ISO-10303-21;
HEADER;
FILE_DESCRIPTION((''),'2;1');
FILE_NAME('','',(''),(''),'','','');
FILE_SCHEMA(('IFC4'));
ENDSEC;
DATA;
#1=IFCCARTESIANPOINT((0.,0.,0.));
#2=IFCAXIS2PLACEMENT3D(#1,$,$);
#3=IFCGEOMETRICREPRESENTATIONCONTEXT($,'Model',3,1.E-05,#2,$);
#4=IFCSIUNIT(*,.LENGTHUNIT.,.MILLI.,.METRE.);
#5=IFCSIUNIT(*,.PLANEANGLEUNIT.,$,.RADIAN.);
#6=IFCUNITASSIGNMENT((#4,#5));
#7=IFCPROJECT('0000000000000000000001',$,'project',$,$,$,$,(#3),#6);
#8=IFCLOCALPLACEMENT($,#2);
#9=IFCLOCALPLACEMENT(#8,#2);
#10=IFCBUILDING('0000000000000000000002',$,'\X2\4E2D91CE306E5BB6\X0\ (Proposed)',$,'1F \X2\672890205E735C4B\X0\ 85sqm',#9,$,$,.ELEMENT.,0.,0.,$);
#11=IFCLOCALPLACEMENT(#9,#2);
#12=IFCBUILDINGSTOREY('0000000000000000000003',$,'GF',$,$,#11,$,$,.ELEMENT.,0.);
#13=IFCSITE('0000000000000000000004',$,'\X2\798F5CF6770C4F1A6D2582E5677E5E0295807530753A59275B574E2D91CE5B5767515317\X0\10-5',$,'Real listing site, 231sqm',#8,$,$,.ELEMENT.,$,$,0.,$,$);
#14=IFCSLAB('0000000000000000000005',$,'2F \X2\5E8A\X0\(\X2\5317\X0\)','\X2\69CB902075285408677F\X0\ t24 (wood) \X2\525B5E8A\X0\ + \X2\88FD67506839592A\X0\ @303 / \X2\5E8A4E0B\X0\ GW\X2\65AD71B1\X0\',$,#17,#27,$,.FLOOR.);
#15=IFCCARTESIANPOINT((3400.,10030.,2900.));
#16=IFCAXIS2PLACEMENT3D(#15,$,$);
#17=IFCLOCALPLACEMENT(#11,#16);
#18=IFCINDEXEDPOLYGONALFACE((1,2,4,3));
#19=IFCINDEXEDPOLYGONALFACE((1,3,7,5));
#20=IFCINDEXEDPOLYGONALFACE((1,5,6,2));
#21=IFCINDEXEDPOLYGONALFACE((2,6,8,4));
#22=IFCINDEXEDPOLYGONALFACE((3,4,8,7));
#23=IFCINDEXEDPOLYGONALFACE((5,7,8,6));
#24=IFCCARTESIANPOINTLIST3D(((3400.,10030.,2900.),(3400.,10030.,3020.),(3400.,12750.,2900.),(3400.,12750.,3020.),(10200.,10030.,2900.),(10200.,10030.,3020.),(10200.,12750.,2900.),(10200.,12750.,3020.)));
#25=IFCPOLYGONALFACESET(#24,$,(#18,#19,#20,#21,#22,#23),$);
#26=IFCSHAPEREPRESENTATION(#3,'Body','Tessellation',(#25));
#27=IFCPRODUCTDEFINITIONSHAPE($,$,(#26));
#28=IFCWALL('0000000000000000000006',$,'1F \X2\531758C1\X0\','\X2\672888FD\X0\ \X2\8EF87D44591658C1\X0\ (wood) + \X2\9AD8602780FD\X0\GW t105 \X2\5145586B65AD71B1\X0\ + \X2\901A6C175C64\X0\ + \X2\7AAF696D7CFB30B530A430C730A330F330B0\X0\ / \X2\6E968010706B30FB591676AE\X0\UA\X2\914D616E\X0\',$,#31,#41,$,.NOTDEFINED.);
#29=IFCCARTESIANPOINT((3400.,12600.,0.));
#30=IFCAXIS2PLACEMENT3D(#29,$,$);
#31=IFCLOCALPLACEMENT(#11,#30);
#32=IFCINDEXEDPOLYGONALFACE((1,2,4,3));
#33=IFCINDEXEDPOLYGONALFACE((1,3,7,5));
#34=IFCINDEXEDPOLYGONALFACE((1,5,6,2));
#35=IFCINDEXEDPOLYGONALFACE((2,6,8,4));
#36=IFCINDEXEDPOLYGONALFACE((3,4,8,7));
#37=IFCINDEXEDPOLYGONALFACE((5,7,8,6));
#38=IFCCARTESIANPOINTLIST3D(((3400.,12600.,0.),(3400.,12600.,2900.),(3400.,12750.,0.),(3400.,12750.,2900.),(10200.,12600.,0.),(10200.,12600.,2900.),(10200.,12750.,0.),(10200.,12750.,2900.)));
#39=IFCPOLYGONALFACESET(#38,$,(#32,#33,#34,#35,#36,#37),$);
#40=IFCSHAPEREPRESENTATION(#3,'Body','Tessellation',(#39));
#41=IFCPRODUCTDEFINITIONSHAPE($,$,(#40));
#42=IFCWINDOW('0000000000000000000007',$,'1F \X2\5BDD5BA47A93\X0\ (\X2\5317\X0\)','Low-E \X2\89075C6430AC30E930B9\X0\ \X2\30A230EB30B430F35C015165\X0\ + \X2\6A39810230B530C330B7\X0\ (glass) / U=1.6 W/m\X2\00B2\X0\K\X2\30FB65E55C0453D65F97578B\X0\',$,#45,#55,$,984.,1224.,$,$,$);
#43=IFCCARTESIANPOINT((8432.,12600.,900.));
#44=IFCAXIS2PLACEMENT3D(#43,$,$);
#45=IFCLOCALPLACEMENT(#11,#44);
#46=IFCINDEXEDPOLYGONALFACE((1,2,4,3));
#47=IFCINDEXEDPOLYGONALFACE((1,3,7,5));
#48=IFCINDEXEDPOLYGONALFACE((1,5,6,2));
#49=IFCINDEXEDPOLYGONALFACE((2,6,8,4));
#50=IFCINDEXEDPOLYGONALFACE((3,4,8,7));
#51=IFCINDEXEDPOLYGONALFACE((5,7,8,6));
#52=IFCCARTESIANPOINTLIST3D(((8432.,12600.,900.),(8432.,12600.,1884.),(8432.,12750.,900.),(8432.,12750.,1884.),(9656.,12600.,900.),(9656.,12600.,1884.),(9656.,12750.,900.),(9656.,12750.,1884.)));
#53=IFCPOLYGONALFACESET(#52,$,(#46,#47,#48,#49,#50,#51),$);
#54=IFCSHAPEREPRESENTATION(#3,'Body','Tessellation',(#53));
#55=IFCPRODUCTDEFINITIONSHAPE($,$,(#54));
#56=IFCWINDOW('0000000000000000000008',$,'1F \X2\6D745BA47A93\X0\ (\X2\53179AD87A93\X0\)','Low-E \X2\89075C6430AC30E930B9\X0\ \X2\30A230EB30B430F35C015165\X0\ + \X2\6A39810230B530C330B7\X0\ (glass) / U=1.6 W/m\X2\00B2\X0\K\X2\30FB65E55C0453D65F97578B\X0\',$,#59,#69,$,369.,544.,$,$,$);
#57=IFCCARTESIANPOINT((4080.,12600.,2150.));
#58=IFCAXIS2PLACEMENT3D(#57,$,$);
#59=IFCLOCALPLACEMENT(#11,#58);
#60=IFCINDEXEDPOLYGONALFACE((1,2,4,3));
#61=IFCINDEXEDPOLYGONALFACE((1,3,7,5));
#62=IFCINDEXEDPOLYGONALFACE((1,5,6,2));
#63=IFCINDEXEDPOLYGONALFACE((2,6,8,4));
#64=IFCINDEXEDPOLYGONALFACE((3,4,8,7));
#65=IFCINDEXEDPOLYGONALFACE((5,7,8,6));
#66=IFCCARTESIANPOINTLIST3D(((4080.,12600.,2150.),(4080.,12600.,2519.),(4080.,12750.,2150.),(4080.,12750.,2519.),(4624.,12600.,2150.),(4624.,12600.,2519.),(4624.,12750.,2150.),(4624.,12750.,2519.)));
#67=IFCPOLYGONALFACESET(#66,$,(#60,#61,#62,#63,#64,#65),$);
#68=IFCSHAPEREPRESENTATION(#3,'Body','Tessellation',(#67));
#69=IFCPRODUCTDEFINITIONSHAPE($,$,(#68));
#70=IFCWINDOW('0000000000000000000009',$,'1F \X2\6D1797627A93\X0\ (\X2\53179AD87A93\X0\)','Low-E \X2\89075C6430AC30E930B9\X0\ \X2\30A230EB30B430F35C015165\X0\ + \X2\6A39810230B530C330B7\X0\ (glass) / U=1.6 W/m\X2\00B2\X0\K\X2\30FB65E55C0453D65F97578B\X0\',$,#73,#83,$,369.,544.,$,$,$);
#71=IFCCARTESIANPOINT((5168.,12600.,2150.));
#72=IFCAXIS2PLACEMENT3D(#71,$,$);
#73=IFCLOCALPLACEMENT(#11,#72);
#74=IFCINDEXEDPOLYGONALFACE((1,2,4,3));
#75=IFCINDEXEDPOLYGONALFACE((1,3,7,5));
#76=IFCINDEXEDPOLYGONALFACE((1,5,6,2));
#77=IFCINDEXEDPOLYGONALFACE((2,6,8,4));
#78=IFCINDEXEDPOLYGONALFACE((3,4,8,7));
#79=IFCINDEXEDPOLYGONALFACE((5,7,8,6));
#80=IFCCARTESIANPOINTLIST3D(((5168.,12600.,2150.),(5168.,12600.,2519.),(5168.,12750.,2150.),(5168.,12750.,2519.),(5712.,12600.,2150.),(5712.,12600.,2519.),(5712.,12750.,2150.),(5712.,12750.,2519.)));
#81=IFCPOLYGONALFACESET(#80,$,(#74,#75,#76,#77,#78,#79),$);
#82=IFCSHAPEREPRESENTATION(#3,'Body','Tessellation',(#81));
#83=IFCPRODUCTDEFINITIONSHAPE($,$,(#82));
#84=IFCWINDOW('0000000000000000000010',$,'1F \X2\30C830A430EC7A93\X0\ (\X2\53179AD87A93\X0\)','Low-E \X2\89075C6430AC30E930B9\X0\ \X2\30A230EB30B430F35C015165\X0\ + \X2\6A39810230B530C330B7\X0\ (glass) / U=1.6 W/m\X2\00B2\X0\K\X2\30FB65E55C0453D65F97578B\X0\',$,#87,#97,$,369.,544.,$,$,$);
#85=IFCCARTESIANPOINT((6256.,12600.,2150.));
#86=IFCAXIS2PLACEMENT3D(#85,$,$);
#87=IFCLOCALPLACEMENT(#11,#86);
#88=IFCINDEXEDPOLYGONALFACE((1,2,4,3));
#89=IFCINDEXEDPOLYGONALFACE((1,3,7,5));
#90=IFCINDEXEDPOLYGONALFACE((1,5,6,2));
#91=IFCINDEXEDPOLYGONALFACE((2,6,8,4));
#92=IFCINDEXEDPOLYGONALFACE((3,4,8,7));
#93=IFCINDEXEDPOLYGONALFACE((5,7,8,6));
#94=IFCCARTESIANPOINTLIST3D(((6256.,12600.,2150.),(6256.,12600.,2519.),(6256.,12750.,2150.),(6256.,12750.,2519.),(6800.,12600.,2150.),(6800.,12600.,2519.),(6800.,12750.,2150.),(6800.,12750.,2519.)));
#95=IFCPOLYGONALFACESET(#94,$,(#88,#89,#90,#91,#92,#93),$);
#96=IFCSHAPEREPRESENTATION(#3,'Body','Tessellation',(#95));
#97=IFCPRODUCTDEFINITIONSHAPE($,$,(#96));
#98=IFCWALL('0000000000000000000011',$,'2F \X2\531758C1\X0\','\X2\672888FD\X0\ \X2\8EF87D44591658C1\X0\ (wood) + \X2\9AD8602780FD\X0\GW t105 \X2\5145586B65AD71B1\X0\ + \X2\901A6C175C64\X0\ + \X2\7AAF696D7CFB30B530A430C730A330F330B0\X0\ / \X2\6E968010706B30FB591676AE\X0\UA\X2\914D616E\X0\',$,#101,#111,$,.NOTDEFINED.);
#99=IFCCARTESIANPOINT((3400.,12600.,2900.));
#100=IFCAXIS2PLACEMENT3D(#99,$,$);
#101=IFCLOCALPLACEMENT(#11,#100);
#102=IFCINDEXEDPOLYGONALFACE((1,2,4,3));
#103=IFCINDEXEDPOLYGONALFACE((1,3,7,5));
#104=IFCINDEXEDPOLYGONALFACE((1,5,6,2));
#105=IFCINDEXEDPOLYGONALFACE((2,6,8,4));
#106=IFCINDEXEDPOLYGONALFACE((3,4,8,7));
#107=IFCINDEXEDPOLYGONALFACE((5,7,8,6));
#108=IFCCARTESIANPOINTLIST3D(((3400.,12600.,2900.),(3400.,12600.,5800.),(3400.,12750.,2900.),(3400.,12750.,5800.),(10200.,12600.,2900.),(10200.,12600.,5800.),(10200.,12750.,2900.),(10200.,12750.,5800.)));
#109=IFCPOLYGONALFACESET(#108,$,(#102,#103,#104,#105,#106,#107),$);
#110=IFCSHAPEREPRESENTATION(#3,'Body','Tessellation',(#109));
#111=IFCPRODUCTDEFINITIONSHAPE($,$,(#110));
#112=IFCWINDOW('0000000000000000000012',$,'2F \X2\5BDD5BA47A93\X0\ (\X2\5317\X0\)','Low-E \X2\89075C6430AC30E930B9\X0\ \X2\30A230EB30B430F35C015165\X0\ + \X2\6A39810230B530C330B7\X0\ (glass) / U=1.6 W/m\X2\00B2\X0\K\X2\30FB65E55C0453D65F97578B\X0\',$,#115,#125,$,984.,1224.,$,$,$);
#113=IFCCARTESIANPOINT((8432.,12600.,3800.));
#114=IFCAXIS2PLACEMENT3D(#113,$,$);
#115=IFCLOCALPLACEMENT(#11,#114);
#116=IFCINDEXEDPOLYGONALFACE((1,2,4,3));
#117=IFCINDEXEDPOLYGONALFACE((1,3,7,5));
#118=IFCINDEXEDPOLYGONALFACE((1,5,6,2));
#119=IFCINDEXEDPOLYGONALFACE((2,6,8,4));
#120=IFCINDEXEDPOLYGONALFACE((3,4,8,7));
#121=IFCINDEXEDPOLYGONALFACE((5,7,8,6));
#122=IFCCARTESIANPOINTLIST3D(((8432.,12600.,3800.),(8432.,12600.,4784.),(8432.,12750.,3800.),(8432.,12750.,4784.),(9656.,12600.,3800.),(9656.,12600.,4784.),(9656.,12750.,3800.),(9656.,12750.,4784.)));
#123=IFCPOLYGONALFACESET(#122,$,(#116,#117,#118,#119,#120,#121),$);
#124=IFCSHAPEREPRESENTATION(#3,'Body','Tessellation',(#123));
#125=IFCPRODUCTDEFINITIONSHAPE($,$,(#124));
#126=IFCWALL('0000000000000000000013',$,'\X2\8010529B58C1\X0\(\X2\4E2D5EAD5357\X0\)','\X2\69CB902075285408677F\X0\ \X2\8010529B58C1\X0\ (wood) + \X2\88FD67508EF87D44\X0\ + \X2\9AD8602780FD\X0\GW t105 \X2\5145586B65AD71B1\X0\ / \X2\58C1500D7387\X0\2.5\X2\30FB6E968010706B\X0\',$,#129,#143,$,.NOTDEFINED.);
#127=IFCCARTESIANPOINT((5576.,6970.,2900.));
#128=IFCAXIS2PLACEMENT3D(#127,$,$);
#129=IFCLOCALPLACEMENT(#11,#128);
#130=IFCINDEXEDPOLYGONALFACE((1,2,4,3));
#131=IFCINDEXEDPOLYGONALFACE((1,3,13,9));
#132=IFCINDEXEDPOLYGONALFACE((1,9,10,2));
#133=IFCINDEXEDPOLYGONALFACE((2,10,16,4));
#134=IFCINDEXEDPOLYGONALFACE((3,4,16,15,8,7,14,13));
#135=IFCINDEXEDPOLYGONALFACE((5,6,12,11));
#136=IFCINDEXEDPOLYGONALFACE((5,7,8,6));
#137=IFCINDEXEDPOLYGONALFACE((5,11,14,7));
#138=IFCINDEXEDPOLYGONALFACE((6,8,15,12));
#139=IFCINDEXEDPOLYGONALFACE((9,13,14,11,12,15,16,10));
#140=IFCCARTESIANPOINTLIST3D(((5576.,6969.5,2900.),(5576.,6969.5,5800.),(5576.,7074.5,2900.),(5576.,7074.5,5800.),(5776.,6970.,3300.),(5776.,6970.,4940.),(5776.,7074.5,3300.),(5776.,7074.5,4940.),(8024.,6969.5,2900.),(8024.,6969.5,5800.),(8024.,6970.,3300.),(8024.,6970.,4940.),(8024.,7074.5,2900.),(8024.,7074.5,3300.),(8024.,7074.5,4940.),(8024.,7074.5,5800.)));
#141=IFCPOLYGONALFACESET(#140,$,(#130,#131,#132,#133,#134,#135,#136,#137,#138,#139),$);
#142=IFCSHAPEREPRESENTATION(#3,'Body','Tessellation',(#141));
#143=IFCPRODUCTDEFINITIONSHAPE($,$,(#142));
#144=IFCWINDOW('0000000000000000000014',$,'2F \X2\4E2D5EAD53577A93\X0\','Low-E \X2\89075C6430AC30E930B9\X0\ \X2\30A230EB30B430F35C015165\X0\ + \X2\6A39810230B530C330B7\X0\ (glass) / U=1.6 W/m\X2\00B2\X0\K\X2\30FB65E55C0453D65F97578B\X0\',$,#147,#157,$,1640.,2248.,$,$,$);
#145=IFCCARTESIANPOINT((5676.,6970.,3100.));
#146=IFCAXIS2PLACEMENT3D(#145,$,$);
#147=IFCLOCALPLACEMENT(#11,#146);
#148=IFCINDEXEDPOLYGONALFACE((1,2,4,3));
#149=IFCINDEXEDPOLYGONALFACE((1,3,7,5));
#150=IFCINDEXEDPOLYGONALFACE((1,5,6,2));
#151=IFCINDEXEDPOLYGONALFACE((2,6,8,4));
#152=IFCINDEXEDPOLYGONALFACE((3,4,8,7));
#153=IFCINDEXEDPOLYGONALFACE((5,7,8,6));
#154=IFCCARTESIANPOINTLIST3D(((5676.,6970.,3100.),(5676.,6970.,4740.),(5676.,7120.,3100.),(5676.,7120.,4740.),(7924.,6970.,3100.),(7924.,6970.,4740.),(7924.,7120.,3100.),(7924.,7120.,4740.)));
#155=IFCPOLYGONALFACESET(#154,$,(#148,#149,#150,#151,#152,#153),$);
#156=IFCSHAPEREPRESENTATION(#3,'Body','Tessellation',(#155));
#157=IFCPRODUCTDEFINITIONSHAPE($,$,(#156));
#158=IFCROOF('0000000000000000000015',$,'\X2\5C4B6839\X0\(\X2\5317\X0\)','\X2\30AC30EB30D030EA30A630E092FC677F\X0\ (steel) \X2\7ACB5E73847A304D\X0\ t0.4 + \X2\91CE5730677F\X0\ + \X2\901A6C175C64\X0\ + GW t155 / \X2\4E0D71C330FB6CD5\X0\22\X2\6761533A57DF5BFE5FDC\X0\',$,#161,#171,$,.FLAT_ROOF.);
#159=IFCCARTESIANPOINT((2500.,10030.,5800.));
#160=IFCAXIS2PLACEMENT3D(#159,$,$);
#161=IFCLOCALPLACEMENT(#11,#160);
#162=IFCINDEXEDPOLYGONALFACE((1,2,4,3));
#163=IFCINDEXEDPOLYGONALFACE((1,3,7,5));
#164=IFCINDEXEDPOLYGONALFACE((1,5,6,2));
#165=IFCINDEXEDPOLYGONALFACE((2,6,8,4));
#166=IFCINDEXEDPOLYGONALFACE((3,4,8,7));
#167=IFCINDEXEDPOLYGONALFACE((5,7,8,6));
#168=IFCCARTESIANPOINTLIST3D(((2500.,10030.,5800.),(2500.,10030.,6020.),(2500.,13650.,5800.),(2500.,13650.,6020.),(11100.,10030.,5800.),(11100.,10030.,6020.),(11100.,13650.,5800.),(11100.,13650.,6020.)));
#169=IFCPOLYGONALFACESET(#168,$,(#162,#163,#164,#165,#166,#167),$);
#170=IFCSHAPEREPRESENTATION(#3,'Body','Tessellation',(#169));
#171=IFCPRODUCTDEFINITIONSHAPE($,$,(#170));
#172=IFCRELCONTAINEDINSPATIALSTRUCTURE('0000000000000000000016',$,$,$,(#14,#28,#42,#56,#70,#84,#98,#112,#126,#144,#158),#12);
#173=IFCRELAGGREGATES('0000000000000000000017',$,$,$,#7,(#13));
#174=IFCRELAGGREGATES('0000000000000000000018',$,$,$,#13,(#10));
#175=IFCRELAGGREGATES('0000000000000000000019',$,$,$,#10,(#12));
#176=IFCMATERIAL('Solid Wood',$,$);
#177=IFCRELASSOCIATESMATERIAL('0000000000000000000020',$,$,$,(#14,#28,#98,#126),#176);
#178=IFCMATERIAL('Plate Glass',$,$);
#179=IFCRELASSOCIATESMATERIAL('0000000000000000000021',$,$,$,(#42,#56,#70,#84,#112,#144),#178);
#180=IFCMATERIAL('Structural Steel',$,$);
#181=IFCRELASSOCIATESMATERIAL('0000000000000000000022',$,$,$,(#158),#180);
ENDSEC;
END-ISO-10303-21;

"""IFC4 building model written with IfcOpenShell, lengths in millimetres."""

from ifc_helpers import new_model, si_unit, frame, frame_2d, origin, place, context, project, spatial, rectangle, extrude, material, element, fill, save


model = new_model("IFC4")

# Units and contexts
model_context = context("Model", 3, precision=1e-05, world=origin())
ifc_project = project(units=[si_unit("LENGTHUNIT", "METRE", prefix="MILLI"), si_unit("PLANEANGLEUNIT", "RADIAN")], contexts=[model_context])

# Site, building, storey
site_placement = place(None, origin())
site = spatial("IfcSite", under=ifc_project, at=site_placement, Name="福島県会津若松市門田町大字中野字村北10-5", ObjectType="Real listing site, 231sqm", CompositionType="ELEMENT", RefElevation=0.0)
building_placement = place(site_placement, origin())
building = spatial("IfcBuilding", under=site, at=building_placement, Name="中野の家 (Proposed)", ObjectType="1F 木造平屋 85sqm", CompositionType="ELEMENT", ElevationOfRefHeight=0.0, ElevationOfTerrain=0.0)
storey_placement = place(building_placement, origin())
storey = spatial("IfcBuildingStorey", under=building, at=storey_placement, Name="GF", CompositionType="ELEMENT", Elevation=0.0)

# Slab
ifc_material_1 = material(Name="Solid Wood")
slab_1_placement = place(storey_placement, frame((3400.0, 10030.0, 2900.0)))
element("IfcSlab", 1, at=slab_1_placement, inside=storey, material=ifc_material_1, Name="2F 床(北)", Description="構造用合板 t24 (wood) 剛床 + 製材根太 @303 / 床下 GW断熱", PredefinedType="FLOOR", context=model_context, shape_type="SweptSolid", body=[
    extrude(rectangle(XDim=6800.0, YDim=2720.0, at=frame_2d((3400.0, 1360.0))), frame((3400.0, 10030.0, 2900.0)), (0.0, 0.0, 1.0), 120.0),
])

# Wall, openings, windows
wall_1_placement = place(storey_placement, frame((3400.0, 12600.0, 0.0)))
wall_1 = element("IfcWall", 2, at=wall_1_placement, inside=storey, material=ifc_material_1, Name="1F 北壁", Description="木製 軸組外壁 (wood) + 高性能GW t105 充填断熱 + 通気層 + 窯業系サイディング / 準耐火・外皮UA配慮", PredefinedType="NOTDEFINED", context=model_context, shape_type="SweptSolid", body=[
    extrude(rectangle(XDim=6800.0, YDim=150.0, at=frame_2d((3400.0, 75.0))), frame((3400.0, 12600.0, 0.0)), (0.0, 0.0, 1.0), 2900.0),
])
opening_1_placement = place(storey_placement, frame((8432.0, 12600.0, 900.0)))
opening_1 = element("IfcOpeningElement", 3, at=opening_1_placement, cuts=wall_1, PredefinedType="NOTDEFINED", context=model_context, shape_type="SweptSolid", body=[
    extrude(rectangle(XDim=1224.0, YDim=150.0, at=frame_2d((612.0, 75.0))), frame((8432.0, 12600.0, 900.0)), (0.0, 0.0, 1.0), 984.0),
])
opening_2_placement = place(storey_placement, frame((4080.0, 12600.0, 2150.0)))
opening_2 = element("IfcOpeningElement", 4, at=opening_2_placement, cuts=wall_1, PredefinedType="NOTDEFINED", context=model_context, shape_type="SweptSolid", body=[
    extrude(rectangle(XDim=544.0, YDim=150.0, at=frame_2d((272.0, 75.0))), frame((4080.0, 12600.0, 2150.0)), (0.0, 0.0, 1.0), 369.0),
])
opening_3_placement = place(storey_placement, frame((5168.0, 12600.0, 2150.0)))
opening_3 = element("IfcOpeningElement", 5, at=opening_3_placement, cuts=wall_1, PredefinedType="NOTDEFINED", context=model_context, shape_type="SweptSolid", body=[
    extrude(rectangle(XDim=544.0, YDim=150.0, at=frame_2d((272.0, 75.0))), frame((5168.0, 12600.0, 2150.0)), (0.0, 0.0, 1.0), 369.0),
])
opening_4_placement = place(storey_placement, frame((6256.0, 12600.0, 2150.0)))
opening_4 = element("IfcOpeningElement", 6, at=opening_4_placement, cuts=wall_1, PredefinedType="NOTDEFINED", context=model_context, shape_type="SweptSolid", body=[
    extrude(rectangle(XDim=544.0, YDim=150.0, at=frame_2d((272.0, 75.0))), frame((6256.0, 12600.0, 2150.0)), (0.0, 0.0, 1.0), 369.0),
])
ifc_material_2 = material(Name="Plate Glass")
window_1_placement = place(storey_placement, frame((8432.0, 12600.0, 900.0)))
window_1 = element("IfcWindow", 7, at=window_1_placement, inside=storey, material=ifc_material_2, Name="1F 寝室窓 (北)", Description="Low-E 複層ガラス アルゴン封入 + 樹脂サッシ (glass) / U=1.6 W/m²K・日射取得型", OverallHeight=984.0, OverallWidth=1224.0, context=model_context, shape_type="SweptSolid", body=[
    extrude(rectangle(XDim=1224.0, YDim=150.0, at=frame_2d((612.0, 75.0))), frame((8432.0, 12600.0, 900.0)), (0.0, 0.0, 1.0), 984.0),
])
fill(opening_1, window_1)
window_2_placement = place(storey_placement, frame((4080.0, 12600.0, 2150.0)))
window_2 = element("IfcWindow", 8, at=window_2_placement, inside=storey, material=ifc_material_2, Name="1F 浴室窓 (北高窓)", Description="Low-E 複層ガラス アルゴン封入 + 樹脂サッシ (glass) / U=1.6 W/m²K・日射取得型", OverallHeight=369.0, OverallWidth=544.0, context=model_context, shape_type="SweptSolid", body=[
    extrude(rectangle(XDim=544.0, YDim=150.0, at=frame_2d((272.0, 75.0))), frame((4080.0, 12600.0, 2150.0)), (0.0, 0.0, 1.0), 369.0),
])
fill(opening_2, window_2)
window_3_placement = place(storey_placement, frame((5168.0, 12600.0, 2150.0)))
window_3 = element("IfcWindow", 9, at=window_3_placement, inside=storey, material=ifc_material_2, Name="1F 洗面窓 (北高窓)", Description="Low-E 複層ガラス アルゴン封入 + 樹脂サッシ (glass) / U=1.6 W/m²K・日射取得型", OverallHeight=369.0, OverallWidth=544.0, context=model_context, shape_type="SweptSolid", body=[
    extrude(rectangle(XDim=544.0, YDim=150.0, at=frame_2d((272.0, 75.0))), frame((5168.0, 12600.0, 2150.0)), (0.0, 0.0, 1.0), 369.0),
])
fill(opening_3, window_3)
window_4_placement = place(storey_placement, frame((6256.0, 12600.0, 2150.0)))
window_4 = element("IfcWindow", 10, at=window_4_placement, inside=storey, material=ifc_material_2, Name="1F トイレ窓 (北高窓)", Description="Low-E 複層ガラス アルゴン封入 + 樹脂サッシ (glass) / U=1.6 W/m²K・日射取得型", OverallHeight=369.0, OverallWidth=544.0, context=model_context, shape_type="SweptSolid", body=[
    extrude(rectangle(XDim=544.0, YDim=150.0, at=frame_2d((272.0, 75.0))), frame((6256.0, 12600.0, 2150.0)), (0.0, 0.0, 1.0), 369.0),
])
fill(opening_4, window_4)

# Walls, openings, windows
wall_2_placement = place(storey_placement, frame((3400.0, 12600.0, 2900.0)))
wall_2 = element("IfcWall", 11, at=wall_2_placement, inside=storey, material=ifc_material_1, Name="2F 北壁", Description="木製 軸組外壁 (wood) + 高性能GW t105 充填断熱 + 通気層 + 窯業系サイディング / 準耐火・外皮UA配慮", PredefinedType="NOTDEFINED", context=model_context, shape_type="SweptSolid", body=[
    extrude(rectangle(XDim=6800.0, YDim=150.0, at=frame_2d((3400.0, 75.0))), frame((3400.0, 12600.0, 2900.0)), (0.0, 0.0, 1.0), 2900.0),
])
opening_5_placement = place(storey_placement, frame((8432.0, 12600.0, 3800.0)))
opening_5 = element("IfcOpeningElement", 12, at=opening_5_placement, cuts=wall_2, PredefinedType="NOTDEFINED", context=model_context, shape_type="SweptSolid", body=[
    extrude(rectangle(XDim=1224.0, YDim=150.0, at=frame_2d((612.0, 75.0))), frame((8432.0, 12600.0, 3800.0)), (0.0, 0.0, 1.0), 984.0),
])
window_5_placement = place(storey_placement, frame((8432.0, 12600.0, 3800.0)))
window_5 = element("IfcWindow", 13, at=window_5_placement, inside=storey, material=ifc_material_2, Name="2F 寝室窓 (北)", Description="Low-E 複層ガラス アルゴン封入 + 樹脂サッシ (glass) / U=1.6 W/m²K・日射取得型", OverallHeight=984.0, OverallWidth=1224.0, context=model_context, shape_type="SweptSolid", body=[
    extrude(rectangle(XDim=1224.0, YDim=150.0, at=frame_2d((612.0, 75.0))), frame((8432.0, 12600.0, 3800.0)), (0.0, 0.0, 1.0), 984.0),
])
fill(opening_5, window_5)
wall_3_placement = place(storey_placement, frame((5576.0, 6970.0, 2900.0)))
wall_3 = element("IfcWall", 14, at=wall_3_placement, inside=storey, material=ifc_material_1, Name="耐力壁(中庭南)", Description="構造用合板 耐力壁 (wood) + 製材軸組 + 高性能GW t105 充填断熱 / 壁倍率2.5・準耐火", PredefinedType="NOTDEFINED", context=model_context, shape_type="SweptSolid", body=[
    extrude(rectangle(XDim=2448.0, YDim=105.0, at=frame_2d((1224.0, 52.0))), frame((5576.0, 6970.0, 2900.0)), (0.0, 0.0, 1.0), 2900.0),
])
opening_6_placement = place(storey_placement, frame((5676.0, 6970.0, 3100.0)))
opening_6 = element("IfcOpeningElement", 15, at=opening_6_placement, cuts=wall_3, PredefinedType="NOTDEFINED", context=model_context, shape_type="SweptSolid", body=[
    extrude(rectangle(XDim=2248.0, YDim=150.0, at=frame_2d((1124.0, 75.0))), frame((5676.0, 6970.0, 3100.0)), (0.0, 0.0, 1.0), 1640.0),
])
window_6_placement = place(storey_placement, frame((5676.0, 6970.0, 3100.0)))
window_6 = element("IfcWindow", 16, at=window_6_placement, inside=storey, material=ifc_material_2, Name="2F 中庭南窓", Description="Low-E 複層ガラス アルゴン封入 + 樹脂サッシ (glass) / U=1.6 W/m²K・日射取得型", OverallHeight=1640.0, OverallWidth=2248.0, context=model_context, shape_type="SweptSolid", body=[
    extrude(rectangle(XDim=2248.0, YDim=150.0, at=frame_2d((1124.0, 75.0))), frame((5676.0, 6970.0, 3100.0)), (0.0, 0.0, 1.0), 1640.0),
])
fill(opening_6, window_6)

# Roof
ifc_material_3 = material(Name="Structural Steel")
for number, where, name in (
    (17, (2500.0, 10030.0, 5800.0), "屋根(北)"),
):
    element("IfcRoof", number, at=place(storey_placement, frame(where)), inside=storey, material=ifc_material_3, Name=name, Description="ガルバリウム鋼板 (steel) 立平葺き t0.4 + 野地板 + 通気層 + GW t155 / 不燃・法22条区域対応", PredefinedType="FLAT_ROOF", context=model_context, shape_type="SweptSolid", body=[
        extrude(rectangle(XDim=8600.0, YDim=3620.0, at=frame_2d((4300.0, 1810.0))), frame((2500.0, 10030.0, 5800.0)), (0.0, 0.0, 1.0), 220.0),
    ])

save(model, "model.ifc")
